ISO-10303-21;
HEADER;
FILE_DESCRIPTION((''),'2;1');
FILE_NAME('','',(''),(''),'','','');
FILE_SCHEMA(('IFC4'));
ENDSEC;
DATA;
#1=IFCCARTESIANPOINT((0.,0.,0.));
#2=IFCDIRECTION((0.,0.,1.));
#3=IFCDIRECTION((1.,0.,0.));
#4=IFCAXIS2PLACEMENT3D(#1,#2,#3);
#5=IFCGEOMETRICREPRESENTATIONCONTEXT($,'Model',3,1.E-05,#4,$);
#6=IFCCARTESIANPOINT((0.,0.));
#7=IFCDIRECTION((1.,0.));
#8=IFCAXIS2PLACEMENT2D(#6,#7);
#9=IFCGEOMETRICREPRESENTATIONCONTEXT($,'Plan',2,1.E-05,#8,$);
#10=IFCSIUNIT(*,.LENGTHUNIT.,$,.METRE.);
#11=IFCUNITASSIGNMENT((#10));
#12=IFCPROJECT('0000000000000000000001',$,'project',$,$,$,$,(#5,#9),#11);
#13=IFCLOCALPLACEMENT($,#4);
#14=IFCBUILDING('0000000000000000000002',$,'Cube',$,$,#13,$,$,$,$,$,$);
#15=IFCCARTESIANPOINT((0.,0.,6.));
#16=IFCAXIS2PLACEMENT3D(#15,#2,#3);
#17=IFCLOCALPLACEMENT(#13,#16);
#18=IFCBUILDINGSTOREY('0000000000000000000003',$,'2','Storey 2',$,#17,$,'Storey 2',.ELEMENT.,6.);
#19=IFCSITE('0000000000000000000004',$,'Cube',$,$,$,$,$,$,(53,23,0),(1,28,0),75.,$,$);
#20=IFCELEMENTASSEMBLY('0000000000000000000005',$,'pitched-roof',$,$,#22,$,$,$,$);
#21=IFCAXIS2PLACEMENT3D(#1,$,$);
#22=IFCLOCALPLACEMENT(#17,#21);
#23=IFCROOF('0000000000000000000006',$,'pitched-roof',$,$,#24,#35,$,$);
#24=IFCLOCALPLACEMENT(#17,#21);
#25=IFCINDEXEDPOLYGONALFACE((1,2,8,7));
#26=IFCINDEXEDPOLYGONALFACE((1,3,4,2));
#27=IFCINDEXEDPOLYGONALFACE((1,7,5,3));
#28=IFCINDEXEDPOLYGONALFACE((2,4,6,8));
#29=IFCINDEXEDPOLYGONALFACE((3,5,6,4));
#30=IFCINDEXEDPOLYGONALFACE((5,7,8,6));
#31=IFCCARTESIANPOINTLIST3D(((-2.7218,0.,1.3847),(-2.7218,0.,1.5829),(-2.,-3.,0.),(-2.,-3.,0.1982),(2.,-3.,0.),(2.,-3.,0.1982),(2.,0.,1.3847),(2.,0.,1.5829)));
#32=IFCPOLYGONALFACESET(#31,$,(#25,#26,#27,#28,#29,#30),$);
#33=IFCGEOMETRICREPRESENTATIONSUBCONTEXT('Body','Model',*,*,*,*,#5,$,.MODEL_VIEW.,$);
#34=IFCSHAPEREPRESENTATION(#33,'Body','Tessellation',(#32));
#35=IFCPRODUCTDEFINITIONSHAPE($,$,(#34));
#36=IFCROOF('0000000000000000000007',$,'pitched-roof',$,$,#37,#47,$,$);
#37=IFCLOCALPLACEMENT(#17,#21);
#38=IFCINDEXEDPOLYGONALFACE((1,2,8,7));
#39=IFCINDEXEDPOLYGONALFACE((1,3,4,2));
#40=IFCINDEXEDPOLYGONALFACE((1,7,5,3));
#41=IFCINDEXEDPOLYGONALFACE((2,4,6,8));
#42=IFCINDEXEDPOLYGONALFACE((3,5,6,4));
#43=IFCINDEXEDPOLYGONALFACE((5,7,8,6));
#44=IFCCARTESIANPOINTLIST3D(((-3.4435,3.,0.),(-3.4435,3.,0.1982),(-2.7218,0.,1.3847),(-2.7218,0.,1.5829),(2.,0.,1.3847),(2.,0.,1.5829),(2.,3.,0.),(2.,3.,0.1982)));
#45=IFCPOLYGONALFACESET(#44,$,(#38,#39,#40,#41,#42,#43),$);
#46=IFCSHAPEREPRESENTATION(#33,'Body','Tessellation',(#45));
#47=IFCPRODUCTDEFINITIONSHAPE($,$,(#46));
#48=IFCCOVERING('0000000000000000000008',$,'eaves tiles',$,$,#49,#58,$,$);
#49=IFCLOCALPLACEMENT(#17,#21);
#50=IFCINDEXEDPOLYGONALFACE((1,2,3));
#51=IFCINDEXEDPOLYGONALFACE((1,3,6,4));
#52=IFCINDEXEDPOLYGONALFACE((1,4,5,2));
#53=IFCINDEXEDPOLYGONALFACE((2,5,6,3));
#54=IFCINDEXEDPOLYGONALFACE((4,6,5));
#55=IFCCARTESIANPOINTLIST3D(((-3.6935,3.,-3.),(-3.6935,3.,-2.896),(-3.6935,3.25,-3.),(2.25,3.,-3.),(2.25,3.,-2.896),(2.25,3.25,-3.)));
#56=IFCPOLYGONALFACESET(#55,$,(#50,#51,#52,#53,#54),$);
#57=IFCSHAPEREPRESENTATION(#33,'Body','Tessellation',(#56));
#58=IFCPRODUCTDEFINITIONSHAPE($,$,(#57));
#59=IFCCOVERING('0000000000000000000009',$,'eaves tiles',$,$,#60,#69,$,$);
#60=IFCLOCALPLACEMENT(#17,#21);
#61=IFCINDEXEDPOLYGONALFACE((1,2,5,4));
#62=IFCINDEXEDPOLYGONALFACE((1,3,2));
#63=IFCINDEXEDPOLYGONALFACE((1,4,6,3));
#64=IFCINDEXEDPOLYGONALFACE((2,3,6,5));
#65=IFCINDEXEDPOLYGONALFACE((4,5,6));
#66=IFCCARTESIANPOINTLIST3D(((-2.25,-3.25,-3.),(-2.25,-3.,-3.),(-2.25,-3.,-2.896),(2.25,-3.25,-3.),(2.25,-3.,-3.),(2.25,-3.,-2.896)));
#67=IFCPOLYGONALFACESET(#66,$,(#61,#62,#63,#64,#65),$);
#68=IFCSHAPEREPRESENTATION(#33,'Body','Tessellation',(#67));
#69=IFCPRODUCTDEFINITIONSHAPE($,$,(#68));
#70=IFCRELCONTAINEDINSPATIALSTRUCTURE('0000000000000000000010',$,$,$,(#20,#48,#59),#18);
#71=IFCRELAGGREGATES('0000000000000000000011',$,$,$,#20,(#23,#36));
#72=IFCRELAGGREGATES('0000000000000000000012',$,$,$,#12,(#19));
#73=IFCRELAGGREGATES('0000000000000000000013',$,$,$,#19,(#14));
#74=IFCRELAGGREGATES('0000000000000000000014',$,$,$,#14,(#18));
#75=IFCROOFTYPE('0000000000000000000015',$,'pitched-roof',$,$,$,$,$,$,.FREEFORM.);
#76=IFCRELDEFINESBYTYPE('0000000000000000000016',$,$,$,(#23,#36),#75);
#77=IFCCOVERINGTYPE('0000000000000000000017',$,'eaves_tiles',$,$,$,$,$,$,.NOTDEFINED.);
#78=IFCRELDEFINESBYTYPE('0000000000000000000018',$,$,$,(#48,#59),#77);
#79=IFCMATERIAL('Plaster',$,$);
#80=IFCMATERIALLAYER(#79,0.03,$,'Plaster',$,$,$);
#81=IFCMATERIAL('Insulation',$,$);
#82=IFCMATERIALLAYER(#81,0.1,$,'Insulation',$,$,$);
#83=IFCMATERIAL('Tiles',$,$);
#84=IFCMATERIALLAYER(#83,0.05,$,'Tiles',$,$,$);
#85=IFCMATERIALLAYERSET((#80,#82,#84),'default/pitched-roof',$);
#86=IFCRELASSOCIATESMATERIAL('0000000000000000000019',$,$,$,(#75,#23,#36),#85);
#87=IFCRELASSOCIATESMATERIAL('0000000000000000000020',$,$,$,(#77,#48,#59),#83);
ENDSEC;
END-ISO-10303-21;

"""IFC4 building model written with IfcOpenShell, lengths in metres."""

from ifc_helpers import new_model, si_unit, frame, origin, origin_with_axes, origin_2d_with_axis, place, context, subcontext, project, spatial, polyline, outline, extrude, material, layer, layer_set, layer_usage, material_profile, profile_set, profile_usage, type_object, element, aggregate, save


model = new_model("IFC4")

# Units and contexts
model_context = context("Model", 3, precision=1e-05, world=origin_with_axes())
plan_context = context("Plan", 2, precision=1e-05, world=origin_2d_with_axis())
body_context = subcontext(model_context, "Body", "Model", "MODEL_VIEW")
ifc_project = project(units=[si_unit("LENGTHUNIT", "METRE")], contexts=[model_context, plan_context])

# Site, building, storey
site = spatial("IfcSite", under=ifc_project, Name="Cube", RefLatitude=(53, 23, 0), RefLongitude=(1, 28, 0), RefElevation=75.0)
building_placement = place(None, origin_with_axes())
building = spatial("IfcBuilding", under=site, at=building_placement, Name="Cube")
storey_placement = place(building_placement, frame((0.0, 0.0, 6.0), z_axis=(0.0, 0.0, 1.0), x_axis=(1.0, 0.0, 0.0)))
storey = spatial("IfcBuildingStorey", under=building, at=storey_placement, Name="2", Description="Storey 2", LongName="Storey 2", CompositionType="ELEMENT", Elevation=6.0)

# Element assembly, roofs
assembly_placement = place(storey_placement, origin_with_axes())
assembly = element("IfcElementAssembly", 1, at=assembly_placement, inside=storey, Name="pitched-roof")
ifc_material_1 = material(Name="Plaster")
ifc_layer_1 = layer(ifc_material_1, 0.03, Name="Plaster")
ifc_material_2 = material(Name="Insulation")
ifc_layer_2 = layer(ifc_material_2, 0.1, Name="Insulation")
ifc_material_3 = material(Name="Tiles")
ifc_layer_3 = layer(ifc_material_3, 0.05, Name="Tiles")
ifc_layer_set = layer_set([ifc_layer_1, ifc_layer_2, ifc_layer_3], Name="default/pitched-roof")
ifc_layer_usage_1 = layer_usage(ifc_layer_set, "AXIS3", "POSITIVE", 0.0)
roof_type = type_object("IfcRoofType", Name="pitched-roof", PredefinedType="FREEFORM", material=ifc_layer_set)
roof_1_placement = place(assembly_placement, frame((-2.0, -3.0, 0.0), z_axis=(0.0, -0.419069, 0.907954), x_axis=(1.0, 0.0, 0.0)))
roof_1 = element("IfcRoof", 2, at=roof_1_placement, type_object=roof_type, material=ifc_layer_usage_1, Name="pitched-roof", context=body_context, shape_type="SweptSolid", body=[
    extrude(outline(polyline([(0.0, 0.0), (4.0, 0.0), (4.0, 3.3041), (-0.7218, 3.3041), (0.0, 0.0)])), origin(), (0.0, 0.419069, 0.907954), 0.1982),
])
ifc_layer_usage_2 = layer_usage(ifc_layer_set, "AXIS3", "POSITIVE", 0.0)
roof_2_placement = place(assembly_placement, frame((-3.4435, 3.0, 0.0), z_axis=(0.0, 0.419069, 0.907954), x_axis=(-1.0, 0.0, 0.0)))
roof_2 = element("IfcRoof", 3, at=roof_2_placement, type_object=roof_type, material=ifc_layer_usage_2, Name="pitched-roof", context=body_context, shape_type="SweptSolid", body=[
    extrude(outline(polyline([(0.0, 0.0), (-0.7218, 3.3041), (-5.4435, 3.3041), (-5.4435, 0.0), (0.0, 0.0)])), origin(), (0.0, 0.419069, 0.907954), 0.1982),
])
aggregate(assembly, [roof_1, roof_2])

# Coverings
ifc_material_profile_1 = material_profile(ifc_material_3, outline(polyline([(0.25, 0.0), (0.0, 0.0), (0.0, 0.104), (0.25, 0.0)])))
ifc_profile_set_1 = profile_set([ifc_material_profile_1])
ifc_profile_usage_1 = profile_usage(ifc_profile_set_1)
covering_type_1 = type_object("IfcCoveringType", Name="eaves_tiles", PredefinedType="NOTDEFINED", material=ifc_profile_set_1)
covering_1_placement = place(storey_placement, frame((-3.6935, 3.0, -3.0), z_axis=(1.0, 0.0, 0.0), x_axis=(0.0, 1.0, 0.0)))
element("IfcCovering", 4, at=covering_1_placement, inside=storey, type_object=covering_type_1, material=ifc_profile_usage_1, Name="eaves tiles", context=body_context, shape_type="SweptSolid", body=[
    extrude(outline(polyline([(0.25, 0.0), (0.0, 0.0), (0.0, 0.104), (0.25, 0.0)])), origin_with_axes(), (0.0, 0.0, 1.0), 5.9435),
])
ifc_profile_usage_2 = profile_usage(ifc_profile_set_1)
covering_2_placement = place(storey_placement, frame((2.25, -3.0, -3.0), z_axis=(-1.0, 0.0, 0.0), x_axis=(0.0, -1.0, 0.0)))
element("IfcCovering", 5, at=covering_2_placement, inside=storey, type_object=covering_type_1, material=ifc_profile_usage_2, Name="eaves tiles", context=body_context, shape_type="SweptSolid", body=[
    extrude(outline(polyline([(0.25, 0.0), (0.0, 0.0), (0.0, 0.104), (0.25, 0.0)])), origin_with_axes(), (0.0, 0.0, 1.0), 4.5),
])

save(model, "model.ifc")
